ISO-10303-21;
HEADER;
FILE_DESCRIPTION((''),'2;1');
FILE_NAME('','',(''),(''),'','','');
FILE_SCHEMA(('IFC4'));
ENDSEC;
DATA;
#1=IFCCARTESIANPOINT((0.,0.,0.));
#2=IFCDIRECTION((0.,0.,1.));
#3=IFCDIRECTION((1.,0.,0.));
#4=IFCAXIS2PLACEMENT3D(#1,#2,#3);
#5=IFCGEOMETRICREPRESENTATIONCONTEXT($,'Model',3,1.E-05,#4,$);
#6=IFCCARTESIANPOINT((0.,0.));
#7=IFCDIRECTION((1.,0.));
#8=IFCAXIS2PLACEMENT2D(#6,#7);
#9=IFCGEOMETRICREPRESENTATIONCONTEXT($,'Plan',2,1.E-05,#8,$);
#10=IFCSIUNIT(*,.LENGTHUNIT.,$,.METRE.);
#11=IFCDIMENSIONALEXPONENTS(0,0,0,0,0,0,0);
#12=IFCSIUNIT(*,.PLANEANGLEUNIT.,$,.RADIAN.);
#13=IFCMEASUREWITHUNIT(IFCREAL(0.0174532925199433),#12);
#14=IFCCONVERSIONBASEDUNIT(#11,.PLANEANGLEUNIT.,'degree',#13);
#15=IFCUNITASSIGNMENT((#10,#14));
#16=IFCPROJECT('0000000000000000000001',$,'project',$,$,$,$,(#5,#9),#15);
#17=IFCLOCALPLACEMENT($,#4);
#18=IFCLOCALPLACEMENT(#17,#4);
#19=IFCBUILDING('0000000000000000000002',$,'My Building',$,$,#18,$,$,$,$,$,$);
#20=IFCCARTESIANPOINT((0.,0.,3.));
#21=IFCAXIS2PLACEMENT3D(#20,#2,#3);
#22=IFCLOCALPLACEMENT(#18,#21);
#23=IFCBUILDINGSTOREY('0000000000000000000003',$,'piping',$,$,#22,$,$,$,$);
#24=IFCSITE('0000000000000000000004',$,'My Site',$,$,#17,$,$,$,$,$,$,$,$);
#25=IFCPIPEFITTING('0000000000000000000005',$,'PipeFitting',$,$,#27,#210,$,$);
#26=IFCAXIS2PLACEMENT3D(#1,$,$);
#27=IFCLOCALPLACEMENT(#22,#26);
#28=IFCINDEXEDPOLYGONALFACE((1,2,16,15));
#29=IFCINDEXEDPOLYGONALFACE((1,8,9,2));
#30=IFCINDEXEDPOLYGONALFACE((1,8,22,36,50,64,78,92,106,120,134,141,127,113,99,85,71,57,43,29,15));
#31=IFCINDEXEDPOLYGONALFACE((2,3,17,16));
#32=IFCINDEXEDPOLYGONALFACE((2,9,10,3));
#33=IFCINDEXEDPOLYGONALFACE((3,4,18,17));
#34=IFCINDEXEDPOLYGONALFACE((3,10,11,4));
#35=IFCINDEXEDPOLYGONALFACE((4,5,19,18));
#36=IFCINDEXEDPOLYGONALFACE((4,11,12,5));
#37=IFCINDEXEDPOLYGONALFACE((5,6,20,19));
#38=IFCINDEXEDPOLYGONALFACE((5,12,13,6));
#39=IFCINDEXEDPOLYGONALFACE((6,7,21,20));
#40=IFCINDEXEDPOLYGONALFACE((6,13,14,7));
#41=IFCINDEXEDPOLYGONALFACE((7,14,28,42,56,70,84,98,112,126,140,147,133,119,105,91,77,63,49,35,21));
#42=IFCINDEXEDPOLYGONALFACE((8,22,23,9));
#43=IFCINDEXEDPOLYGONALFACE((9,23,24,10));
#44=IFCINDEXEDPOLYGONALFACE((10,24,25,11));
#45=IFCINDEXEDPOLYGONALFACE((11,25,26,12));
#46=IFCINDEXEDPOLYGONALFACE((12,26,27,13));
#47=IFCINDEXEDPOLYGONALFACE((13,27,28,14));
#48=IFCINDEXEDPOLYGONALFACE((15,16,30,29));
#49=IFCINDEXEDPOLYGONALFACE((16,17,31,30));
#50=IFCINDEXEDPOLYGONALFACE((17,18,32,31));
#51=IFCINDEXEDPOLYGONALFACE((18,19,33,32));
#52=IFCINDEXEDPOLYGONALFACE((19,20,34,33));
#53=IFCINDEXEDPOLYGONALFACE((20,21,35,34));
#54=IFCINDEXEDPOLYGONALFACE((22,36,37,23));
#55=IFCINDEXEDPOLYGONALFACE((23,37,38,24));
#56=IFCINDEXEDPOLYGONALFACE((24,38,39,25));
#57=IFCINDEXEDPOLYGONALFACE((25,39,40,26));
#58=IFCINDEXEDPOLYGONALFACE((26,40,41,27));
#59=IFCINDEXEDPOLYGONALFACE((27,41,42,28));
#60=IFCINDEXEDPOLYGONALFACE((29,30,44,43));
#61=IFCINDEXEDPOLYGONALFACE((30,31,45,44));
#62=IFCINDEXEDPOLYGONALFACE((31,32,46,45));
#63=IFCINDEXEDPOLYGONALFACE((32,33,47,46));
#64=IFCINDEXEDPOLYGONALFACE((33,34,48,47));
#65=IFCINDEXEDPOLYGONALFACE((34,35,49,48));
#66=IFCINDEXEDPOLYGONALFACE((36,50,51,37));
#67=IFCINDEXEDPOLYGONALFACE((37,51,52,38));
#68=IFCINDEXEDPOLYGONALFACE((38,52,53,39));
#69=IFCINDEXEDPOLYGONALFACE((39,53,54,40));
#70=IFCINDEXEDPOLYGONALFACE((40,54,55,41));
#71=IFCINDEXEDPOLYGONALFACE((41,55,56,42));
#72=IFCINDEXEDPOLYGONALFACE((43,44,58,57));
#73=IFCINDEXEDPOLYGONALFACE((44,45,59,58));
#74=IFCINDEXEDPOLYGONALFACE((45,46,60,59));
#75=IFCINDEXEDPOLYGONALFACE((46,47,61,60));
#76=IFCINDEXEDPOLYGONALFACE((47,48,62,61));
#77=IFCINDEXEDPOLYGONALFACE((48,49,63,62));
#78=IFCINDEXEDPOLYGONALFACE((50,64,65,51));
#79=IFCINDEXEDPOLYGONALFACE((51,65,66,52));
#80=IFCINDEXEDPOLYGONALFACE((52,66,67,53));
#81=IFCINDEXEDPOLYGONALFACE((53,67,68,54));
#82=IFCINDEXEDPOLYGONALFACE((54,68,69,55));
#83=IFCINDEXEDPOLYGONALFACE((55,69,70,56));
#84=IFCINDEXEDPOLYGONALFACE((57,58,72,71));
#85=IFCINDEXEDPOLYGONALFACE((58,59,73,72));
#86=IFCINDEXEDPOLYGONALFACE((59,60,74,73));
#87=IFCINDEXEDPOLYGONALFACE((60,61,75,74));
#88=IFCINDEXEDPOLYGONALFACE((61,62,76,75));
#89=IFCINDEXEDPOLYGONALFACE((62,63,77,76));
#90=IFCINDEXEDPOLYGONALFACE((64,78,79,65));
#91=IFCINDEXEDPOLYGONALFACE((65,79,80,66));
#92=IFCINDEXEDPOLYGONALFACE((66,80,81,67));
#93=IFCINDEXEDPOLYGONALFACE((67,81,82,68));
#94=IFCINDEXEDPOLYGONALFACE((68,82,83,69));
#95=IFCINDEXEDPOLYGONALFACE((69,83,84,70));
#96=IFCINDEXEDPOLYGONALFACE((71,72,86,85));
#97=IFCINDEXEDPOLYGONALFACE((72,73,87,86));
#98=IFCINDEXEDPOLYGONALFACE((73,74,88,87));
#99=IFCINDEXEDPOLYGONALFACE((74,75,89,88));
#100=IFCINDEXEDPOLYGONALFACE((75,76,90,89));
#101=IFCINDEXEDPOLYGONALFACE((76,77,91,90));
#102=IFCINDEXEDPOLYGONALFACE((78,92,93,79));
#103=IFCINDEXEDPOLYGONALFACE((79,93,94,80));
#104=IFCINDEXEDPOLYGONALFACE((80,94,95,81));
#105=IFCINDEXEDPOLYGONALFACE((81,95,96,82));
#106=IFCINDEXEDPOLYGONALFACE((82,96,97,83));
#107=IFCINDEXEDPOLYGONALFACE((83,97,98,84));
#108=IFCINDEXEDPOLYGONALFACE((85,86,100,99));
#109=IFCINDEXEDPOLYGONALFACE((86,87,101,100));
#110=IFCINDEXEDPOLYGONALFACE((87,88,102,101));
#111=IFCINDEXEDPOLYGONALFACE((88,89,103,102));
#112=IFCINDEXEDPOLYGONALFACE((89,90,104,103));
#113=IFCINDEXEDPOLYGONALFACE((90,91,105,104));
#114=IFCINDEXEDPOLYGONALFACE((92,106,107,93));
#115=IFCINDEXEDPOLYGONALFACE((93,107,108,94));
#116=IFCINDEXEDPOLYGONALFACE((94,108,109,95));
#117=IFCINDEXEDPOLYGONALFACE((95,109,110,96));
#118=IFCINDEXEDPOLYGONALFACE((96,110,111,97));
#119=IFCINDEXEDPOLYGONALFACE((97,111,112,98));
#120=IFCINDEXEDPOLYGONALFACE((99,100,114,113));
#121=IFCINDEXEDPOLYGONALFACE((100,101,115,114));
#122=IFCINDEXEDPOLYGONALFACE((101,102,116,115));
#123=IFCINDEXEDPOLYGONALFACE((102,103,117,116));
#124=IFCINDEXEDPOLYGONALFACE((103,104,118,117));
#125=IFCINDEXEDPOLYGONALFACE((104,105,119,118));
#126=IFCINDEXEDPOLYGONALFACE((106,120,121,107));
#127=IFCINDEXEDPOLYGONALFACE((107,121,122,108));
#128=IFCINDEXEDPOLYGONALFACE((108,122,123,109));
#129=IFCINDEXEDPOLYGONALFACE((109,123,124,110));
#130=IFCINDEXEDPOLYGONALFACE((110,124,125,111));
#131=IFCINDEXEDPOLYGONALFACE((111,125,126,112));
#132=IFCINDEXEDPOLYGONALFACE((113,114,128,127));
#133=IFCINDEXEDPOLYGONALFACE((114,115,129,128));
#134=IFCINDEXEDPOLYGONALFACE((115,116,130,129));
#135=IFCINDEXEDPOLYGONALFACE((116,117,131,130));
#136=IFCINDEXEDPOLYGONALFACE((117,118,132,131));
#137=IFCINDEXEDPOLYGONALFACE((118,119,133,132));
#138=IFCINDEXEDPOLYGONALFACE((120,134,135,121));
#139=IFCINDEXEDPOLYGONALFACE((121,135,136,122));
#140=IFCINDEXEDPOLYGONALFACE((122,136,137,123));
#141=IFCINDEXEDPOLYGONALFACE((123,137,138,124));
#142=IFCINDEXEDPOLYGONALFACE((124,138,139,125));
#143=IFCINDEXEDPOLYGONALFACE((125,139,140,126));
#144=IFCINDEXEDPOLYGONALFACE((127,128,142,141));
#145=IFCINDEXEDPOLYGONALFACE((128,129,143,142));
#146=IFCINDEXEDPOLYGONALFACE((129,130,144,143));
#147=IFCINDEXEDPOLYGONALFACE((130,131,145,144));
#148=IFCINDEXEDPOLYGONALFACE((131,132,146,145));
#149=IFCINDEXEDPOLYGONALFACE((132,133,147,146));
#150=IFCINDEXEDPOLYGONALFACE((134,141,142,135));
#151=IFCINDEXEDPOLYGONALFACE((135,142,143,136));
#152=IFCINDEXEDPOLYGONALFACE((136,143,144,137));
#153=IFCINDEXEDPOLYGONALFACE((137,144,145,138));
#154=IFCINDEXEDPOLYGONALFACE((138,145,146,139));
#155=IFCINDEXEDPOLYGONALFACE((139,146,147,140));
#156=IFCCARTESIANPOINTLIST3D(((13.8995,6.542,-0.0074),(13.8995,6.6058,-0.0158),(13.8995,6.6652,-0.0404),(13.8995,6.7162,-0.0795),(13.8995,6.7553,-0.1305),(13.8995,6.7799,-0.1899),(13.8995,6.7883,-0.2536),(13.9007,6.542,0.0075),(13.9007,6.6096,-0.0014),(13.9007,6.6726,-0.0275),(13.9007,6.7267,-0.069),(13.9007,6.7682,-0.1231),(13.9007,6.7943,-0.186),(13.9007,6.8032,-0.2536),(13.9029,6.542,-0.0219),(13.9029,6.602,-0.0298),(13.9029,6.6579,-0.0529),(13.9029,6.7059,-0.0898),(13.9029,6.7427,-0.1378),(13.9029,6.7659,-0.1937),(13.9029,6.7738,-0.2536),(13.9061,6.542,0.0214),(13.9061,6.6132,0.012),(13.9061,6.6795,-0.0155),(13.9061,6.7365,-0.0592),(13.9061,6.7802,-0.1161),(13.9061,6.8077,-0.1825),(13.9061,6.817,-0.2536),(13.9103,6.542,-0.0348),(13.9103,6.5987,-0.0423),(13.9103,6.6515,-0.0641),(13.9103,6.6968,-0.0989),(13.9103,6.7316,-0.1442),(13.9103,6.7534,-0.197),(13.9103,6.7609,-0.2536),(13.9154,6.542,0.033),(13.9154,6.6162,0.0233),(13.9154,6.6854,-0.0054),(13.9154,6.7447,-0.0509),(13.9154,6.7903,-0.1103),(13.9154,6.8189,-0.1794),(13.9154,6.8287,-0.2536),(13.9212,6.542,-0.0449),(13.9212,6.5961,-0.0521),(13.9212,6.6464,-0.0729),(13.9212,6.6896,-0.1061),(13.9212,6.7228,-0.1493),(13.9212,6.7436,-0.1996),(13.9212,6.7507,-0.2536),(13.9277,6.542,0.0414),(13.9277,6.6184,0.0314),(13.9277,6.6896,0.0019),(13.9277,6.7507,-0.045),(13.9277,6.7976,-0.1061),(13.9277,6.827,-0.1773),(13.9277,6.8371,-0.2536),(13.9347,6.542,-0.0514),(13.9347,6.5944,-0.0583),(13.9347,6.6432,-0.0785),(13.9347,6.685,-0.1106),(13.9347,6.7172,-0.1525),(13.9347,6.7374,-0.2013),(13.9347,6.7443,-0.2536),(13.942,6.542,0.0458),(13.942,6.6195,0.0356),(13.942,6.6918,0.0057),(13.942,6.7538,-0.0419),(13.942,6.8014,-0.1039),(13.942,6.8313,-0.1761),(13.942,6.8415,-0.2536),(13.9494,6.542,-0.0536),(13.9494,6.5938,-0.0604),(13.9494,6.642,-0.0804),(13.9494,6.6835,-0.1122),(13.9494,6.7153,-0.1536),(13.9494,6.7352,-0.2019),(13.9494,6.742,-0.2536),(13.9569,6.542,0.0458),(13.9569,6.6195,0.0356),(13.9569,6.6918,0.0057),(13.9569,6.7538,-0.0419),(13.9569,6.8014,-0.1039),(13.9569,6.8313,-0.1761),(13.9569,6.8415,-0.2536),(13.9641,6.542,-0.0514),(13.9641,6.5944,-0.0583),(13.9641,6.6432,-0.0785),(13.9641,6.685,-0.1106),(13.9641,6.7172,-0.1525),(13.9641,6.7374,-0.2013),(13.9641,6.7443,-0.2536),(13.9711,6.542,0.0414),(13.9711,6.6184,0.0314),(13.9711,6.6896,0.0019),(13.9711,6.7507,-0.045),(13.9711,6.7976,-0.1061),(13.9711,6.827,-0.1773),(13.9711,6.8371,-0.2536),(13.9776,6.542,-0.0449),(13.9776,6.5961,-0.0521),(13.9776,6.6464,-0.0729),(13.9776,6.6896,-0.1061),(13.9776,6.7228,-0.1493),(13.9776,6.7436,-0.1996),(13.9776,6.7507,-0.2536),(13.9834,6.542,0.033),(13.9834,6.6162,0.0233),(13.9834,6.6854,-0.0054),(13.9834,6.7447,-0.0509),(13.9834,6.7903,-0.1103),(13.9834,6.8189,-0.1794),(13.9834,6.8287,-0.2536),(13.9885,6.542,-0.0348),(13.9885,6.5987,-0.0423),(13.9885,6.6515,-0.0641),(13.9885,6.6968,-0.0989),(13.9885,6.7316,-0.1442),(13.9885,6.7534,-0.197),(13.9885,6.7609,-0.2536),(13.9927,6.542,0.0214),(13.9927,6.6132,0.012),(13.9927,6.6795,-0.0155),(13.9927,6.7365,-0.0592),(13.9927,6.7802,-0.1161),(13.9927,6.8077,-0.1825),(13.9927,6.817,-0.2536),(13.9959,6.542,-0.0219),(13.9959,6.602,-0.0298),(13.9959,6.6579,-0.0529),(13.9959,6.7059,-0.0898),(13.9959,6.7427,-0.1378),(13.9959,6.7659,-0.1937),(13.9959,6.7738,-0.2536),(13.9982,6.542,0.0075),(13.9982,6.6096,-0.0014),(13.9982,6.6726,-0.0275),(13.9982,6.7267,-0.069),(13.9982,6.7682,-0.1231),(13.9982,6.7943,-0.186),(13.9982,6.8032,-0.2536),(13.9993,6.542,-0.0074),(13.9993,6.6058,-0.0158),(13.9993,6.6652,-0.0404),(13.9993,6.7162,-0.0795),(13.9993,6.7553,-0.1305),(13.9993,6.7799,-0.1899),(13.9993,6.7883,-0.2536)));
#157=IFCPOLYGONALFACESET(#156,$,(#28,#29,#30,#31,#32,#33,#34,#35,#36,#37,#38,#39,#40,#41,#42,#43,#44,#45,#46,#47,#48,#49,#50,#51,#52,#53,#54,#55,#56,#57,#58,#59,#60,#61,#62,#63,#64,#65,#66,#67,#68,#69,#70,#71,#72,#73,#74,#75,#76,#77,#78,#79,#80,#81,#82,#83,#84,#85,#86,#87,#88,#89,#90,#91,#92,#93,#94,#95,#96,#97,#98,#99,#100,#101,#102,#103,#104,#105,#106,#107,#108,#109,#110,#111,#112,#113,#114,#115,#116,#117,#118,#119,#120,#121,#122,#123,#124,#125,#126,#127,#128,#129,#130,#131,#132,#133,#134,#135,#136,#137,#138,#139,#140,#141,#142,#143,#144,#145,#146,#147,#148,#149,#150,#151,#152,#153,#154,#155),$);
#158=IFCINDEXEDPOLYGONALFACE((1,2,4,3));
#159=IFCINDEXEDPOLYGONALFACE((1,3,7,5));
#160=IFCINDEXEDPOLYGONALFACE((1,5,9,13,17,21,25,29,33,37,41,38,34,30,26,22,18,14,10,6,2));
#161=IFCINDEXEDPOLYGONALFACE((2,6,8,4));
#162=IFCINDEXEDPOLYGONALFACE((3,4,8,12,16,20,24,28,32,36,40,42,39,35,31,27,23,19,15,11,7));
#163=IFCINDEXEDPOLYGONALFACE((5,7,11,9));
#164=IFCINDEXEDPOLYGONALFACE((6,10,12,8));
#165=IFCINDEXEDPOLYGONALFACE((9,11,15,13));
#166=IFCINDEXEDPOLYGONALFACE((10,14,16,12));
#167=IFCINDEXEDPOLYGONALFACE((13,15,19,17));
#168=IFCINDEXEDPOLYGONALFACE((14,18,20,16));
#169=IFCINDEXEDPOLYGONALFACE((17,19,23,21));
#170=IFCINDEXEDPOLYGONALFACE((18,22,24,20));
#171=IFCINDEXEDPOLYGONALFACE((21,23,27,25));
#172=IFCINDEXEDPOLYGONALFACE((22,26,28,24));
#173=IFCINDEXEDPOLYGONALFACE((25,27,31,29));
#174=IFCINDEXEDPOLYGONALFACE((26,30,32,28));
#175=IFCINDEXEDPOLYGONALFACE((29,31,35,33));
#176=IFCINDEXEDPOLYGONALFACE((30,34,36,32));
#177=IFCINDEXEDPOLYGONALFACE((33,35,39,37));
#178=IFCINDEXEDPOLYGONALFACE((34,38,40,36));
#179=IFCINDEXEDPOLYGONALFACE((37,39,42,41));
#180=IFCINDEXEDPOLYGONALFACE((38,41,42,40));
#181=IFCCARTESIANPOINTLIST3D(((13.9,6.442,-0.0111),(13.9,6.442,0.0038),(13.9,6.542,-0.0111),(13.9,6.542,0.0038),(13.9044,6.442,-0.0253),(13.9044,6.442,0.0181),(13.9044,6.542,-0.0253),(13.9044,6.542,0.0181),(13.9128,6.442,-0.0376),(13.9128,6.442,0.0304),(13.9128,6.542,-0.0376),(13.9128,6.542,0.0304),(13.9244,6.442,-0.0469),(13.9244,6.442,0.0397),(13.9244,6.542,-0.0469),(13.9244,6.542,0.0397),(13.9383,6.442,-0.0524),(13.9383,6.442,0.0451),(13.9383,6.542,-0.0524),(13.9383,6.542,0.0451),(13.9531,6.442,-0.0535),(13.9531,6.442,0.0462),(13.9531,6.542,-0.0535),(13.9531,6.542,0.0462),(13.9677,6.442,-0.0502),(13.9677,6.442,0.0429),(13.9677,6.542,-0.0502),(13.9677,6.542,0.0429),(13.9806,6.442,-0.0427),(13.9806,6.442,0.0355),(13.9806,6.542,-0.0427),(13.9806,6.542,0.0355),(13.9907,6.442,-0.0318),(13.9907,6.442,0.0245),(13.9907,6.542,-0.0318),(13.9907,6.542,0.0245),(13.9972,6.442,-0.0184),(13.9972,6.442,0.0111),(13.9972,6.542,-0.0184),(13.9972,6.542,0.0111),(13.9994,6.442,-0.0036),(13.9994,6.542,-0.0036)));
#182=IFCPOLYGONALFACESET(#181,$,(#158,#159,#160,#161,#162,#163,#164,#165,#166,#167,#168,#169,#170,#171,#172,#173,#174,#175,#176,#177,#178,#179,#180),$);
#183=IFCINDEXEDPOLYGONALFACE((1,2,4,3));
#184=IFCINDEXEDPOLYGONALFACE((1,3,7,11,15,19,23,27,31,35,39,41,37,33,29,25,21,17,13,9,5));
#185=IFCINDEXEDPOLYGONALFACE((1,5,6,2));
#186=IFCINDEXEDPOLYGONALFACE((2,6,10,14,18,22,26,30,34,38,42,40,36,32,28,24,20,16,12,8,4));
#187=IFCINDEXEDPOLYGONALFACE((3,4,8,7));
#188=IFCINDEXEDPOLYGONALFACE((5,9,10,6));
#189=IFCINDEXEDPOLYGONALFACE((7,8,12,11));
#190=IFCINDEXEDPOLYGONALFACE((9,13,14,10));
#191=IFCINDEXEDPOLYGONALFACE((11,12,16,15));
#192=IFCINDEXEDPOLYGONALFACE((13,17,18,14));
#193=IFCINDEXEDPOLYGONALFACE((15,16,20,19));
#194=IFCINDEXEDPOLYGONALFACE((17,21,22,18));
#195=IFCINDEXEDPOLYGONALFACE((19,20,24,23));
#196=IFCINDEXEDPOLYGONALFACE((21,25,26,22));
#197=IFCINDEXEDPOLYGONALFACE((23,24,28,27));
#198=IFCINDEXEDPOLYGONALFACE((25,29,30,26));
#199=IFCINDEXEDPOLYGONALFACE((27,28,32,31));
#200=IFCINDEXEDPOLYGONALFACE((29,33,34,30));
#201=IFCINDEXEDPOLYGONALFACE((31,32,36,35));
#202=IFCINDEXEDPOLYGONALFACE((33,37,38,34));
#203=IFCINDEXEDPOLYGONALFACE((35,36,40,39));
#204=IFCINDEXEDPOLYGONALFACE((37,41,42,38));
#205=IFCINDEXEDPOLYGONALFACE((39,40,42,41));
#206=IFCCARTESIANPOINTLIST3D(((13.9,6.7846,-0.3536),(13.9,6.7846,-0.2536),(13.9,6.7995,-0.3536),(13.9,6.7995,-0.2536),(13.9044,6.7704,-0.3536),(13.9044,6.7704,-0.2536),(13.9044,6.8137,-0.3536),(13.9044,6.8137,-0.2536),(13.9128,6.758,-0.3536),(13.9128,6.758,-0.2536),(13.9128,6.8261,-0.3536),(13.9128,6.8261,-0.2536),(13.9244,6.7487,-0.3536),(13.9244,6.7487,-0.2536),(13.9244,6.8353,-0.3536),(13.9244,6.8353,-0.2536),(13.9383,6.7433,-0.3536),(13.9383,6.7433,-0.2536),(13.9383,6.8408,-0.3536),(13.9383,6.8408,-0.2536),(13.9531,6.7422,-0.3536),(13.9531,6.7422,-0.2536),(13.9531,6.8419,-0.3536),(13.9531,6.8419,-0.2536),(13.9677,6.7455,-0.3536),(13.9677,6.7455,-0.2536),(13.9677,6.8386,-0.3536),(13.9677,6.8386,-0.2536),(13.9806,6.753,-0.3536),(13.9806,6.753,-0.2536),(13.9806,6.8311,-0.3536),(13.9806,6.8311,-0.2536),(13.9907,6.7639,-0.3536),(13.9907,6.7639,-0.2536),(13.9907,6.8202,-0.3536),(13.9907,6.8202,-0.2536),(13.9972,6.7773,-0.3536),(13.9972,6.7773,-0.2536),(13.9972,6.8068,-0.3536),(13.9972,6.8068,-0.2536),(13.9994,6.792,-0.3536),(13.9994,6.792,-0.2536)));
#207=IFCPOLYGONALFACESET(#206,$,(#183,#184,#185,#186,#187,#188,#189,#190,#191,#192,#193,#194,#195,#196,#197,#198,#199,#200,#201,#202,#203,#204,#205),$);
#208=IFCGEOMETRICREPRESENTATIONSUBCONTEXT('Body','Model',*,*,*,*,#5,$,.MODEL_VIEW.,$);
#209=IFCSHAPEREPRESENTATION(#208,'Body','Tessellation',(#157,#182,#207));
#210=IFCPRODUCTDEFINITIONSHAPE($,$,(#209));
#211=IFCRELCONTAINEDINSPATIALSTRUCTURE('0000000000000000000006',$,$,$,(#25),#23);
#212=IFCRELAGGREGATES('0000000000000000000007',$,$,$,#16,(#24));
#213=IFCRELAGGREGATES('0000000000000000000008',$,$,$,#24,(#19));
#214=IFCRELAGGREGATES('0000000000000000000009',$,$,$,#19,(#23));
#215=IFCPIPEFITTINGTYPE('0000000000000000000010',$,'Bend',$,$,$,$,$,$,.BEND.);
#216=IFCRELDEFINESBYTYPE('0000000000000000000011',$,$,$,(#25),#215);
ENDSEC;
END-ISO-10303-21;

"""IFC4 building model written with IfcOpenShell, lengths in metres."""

from ifc_helpers import new_model, entity, si_unit, converted_unit, frame, origin_with_axes, origin_2d_with_axis, place, context, subcontext, project, spatial, circle, extrude, source, transform, mapped, type_object, type_shapes, element, save


model = new_model("IFC4")

# Units and contexts
model_context = context("Model", 3, precision=1e-05, world=origin_with_axes())
plan_context = context("Plan", 2, precision=1e-05, world=origin_2d_with_axis())
body_context = subcontext(model_context, "Body", "Model", "MODEL_VIEW")
ifc_project = project(units=[si_unit("LENGTHUNIT", "METRE"), converted_unit("PLANEANGLEUNIT", "degree", entity("IfcReal", 0.0174532925199433), si_unit("PLANEANGLEUNIT", "RADIAN"), dimensions=[0, 0, 0, 0, 0, 0, 0])], contexts=[model_context, plan_context])

# Site, building, storey
site_placement = place(None, origin_with_axes())
site = spatial("IfcSite", under=ifc_project, at=site_placement, Name="My Site")
building_placement = place(site_placement, origin_with_axes())
building = spatial("IfcBuilding", under=site, at=building_placement, Name="My Building")
storey_placement = place(building_placement, frame((0.0, 0.0, 3.0), z_axis=(0.0, 0.0, 1.0), x_axis=(1.0, 0.0, 0.0)))
storey = spatial("IfcBuildingStorey", under=building, at=storey_placement, Name="piping")

# Pipe fitting
pipe_fitting_type = type_object("IfcPipeFittingType", Name="Bend", PredefinedType="BEND")
shared_shape = source(origin_with_axes(), body_context, "Body", "SolidModel", [
    entity("IfcSweptDiskSolid", entity("IfcIndexedPolyCurve", entity("IfcCartesianPointList3D", [[0.0, 0.0, -0.1], [0.0, -0.0732, -0.2768], [0.0, -0.25, -0.35]]), [entity("IfcArcIndex", [1, 2, 3])]), 0.05),
    extrude(circle(Radius=0.05), origin_with_axes(), (0.0, 0.0, -1.0), 0.1),
    extrude(circle(Radius=0.05), frame((0.0, -0.25, -0.35), z_axis=(0.0, -1.0, 0.0), x_axis=(1.0, 0.0, 0.0)), (0.0, 0.0, 1.0), 0.1),
])
type_shapes(pipe_fitting_type, [shared_shape])
for number, where, z_axis, x_axis, name in (
    (1, (13.9494, 6.442, -0.0036), (0.0, -1.0, 0.0), (1.0, 0.0, 0.0), "PipeFitting"),
):
    element("IfcPipeFitting", number, at=place(storey_placement, frame(where, z_axis=z_axis, x_axis=x_axis)), inside=storey, type_object=pipe_fitting_type, Name=name, context=body_context, shape_type="MappedRepresentation", body=[
        mapped(shared_shape, transform((0.0, 0.0, 0.0), x_axis=(1.0, 0.0, 0.0), y_axis=(0.0, 1.0, 0.0), z_axis=(0.0, 0.0, 1.0), scale=1.0)),
    ])

save(model, "model.ifc")
